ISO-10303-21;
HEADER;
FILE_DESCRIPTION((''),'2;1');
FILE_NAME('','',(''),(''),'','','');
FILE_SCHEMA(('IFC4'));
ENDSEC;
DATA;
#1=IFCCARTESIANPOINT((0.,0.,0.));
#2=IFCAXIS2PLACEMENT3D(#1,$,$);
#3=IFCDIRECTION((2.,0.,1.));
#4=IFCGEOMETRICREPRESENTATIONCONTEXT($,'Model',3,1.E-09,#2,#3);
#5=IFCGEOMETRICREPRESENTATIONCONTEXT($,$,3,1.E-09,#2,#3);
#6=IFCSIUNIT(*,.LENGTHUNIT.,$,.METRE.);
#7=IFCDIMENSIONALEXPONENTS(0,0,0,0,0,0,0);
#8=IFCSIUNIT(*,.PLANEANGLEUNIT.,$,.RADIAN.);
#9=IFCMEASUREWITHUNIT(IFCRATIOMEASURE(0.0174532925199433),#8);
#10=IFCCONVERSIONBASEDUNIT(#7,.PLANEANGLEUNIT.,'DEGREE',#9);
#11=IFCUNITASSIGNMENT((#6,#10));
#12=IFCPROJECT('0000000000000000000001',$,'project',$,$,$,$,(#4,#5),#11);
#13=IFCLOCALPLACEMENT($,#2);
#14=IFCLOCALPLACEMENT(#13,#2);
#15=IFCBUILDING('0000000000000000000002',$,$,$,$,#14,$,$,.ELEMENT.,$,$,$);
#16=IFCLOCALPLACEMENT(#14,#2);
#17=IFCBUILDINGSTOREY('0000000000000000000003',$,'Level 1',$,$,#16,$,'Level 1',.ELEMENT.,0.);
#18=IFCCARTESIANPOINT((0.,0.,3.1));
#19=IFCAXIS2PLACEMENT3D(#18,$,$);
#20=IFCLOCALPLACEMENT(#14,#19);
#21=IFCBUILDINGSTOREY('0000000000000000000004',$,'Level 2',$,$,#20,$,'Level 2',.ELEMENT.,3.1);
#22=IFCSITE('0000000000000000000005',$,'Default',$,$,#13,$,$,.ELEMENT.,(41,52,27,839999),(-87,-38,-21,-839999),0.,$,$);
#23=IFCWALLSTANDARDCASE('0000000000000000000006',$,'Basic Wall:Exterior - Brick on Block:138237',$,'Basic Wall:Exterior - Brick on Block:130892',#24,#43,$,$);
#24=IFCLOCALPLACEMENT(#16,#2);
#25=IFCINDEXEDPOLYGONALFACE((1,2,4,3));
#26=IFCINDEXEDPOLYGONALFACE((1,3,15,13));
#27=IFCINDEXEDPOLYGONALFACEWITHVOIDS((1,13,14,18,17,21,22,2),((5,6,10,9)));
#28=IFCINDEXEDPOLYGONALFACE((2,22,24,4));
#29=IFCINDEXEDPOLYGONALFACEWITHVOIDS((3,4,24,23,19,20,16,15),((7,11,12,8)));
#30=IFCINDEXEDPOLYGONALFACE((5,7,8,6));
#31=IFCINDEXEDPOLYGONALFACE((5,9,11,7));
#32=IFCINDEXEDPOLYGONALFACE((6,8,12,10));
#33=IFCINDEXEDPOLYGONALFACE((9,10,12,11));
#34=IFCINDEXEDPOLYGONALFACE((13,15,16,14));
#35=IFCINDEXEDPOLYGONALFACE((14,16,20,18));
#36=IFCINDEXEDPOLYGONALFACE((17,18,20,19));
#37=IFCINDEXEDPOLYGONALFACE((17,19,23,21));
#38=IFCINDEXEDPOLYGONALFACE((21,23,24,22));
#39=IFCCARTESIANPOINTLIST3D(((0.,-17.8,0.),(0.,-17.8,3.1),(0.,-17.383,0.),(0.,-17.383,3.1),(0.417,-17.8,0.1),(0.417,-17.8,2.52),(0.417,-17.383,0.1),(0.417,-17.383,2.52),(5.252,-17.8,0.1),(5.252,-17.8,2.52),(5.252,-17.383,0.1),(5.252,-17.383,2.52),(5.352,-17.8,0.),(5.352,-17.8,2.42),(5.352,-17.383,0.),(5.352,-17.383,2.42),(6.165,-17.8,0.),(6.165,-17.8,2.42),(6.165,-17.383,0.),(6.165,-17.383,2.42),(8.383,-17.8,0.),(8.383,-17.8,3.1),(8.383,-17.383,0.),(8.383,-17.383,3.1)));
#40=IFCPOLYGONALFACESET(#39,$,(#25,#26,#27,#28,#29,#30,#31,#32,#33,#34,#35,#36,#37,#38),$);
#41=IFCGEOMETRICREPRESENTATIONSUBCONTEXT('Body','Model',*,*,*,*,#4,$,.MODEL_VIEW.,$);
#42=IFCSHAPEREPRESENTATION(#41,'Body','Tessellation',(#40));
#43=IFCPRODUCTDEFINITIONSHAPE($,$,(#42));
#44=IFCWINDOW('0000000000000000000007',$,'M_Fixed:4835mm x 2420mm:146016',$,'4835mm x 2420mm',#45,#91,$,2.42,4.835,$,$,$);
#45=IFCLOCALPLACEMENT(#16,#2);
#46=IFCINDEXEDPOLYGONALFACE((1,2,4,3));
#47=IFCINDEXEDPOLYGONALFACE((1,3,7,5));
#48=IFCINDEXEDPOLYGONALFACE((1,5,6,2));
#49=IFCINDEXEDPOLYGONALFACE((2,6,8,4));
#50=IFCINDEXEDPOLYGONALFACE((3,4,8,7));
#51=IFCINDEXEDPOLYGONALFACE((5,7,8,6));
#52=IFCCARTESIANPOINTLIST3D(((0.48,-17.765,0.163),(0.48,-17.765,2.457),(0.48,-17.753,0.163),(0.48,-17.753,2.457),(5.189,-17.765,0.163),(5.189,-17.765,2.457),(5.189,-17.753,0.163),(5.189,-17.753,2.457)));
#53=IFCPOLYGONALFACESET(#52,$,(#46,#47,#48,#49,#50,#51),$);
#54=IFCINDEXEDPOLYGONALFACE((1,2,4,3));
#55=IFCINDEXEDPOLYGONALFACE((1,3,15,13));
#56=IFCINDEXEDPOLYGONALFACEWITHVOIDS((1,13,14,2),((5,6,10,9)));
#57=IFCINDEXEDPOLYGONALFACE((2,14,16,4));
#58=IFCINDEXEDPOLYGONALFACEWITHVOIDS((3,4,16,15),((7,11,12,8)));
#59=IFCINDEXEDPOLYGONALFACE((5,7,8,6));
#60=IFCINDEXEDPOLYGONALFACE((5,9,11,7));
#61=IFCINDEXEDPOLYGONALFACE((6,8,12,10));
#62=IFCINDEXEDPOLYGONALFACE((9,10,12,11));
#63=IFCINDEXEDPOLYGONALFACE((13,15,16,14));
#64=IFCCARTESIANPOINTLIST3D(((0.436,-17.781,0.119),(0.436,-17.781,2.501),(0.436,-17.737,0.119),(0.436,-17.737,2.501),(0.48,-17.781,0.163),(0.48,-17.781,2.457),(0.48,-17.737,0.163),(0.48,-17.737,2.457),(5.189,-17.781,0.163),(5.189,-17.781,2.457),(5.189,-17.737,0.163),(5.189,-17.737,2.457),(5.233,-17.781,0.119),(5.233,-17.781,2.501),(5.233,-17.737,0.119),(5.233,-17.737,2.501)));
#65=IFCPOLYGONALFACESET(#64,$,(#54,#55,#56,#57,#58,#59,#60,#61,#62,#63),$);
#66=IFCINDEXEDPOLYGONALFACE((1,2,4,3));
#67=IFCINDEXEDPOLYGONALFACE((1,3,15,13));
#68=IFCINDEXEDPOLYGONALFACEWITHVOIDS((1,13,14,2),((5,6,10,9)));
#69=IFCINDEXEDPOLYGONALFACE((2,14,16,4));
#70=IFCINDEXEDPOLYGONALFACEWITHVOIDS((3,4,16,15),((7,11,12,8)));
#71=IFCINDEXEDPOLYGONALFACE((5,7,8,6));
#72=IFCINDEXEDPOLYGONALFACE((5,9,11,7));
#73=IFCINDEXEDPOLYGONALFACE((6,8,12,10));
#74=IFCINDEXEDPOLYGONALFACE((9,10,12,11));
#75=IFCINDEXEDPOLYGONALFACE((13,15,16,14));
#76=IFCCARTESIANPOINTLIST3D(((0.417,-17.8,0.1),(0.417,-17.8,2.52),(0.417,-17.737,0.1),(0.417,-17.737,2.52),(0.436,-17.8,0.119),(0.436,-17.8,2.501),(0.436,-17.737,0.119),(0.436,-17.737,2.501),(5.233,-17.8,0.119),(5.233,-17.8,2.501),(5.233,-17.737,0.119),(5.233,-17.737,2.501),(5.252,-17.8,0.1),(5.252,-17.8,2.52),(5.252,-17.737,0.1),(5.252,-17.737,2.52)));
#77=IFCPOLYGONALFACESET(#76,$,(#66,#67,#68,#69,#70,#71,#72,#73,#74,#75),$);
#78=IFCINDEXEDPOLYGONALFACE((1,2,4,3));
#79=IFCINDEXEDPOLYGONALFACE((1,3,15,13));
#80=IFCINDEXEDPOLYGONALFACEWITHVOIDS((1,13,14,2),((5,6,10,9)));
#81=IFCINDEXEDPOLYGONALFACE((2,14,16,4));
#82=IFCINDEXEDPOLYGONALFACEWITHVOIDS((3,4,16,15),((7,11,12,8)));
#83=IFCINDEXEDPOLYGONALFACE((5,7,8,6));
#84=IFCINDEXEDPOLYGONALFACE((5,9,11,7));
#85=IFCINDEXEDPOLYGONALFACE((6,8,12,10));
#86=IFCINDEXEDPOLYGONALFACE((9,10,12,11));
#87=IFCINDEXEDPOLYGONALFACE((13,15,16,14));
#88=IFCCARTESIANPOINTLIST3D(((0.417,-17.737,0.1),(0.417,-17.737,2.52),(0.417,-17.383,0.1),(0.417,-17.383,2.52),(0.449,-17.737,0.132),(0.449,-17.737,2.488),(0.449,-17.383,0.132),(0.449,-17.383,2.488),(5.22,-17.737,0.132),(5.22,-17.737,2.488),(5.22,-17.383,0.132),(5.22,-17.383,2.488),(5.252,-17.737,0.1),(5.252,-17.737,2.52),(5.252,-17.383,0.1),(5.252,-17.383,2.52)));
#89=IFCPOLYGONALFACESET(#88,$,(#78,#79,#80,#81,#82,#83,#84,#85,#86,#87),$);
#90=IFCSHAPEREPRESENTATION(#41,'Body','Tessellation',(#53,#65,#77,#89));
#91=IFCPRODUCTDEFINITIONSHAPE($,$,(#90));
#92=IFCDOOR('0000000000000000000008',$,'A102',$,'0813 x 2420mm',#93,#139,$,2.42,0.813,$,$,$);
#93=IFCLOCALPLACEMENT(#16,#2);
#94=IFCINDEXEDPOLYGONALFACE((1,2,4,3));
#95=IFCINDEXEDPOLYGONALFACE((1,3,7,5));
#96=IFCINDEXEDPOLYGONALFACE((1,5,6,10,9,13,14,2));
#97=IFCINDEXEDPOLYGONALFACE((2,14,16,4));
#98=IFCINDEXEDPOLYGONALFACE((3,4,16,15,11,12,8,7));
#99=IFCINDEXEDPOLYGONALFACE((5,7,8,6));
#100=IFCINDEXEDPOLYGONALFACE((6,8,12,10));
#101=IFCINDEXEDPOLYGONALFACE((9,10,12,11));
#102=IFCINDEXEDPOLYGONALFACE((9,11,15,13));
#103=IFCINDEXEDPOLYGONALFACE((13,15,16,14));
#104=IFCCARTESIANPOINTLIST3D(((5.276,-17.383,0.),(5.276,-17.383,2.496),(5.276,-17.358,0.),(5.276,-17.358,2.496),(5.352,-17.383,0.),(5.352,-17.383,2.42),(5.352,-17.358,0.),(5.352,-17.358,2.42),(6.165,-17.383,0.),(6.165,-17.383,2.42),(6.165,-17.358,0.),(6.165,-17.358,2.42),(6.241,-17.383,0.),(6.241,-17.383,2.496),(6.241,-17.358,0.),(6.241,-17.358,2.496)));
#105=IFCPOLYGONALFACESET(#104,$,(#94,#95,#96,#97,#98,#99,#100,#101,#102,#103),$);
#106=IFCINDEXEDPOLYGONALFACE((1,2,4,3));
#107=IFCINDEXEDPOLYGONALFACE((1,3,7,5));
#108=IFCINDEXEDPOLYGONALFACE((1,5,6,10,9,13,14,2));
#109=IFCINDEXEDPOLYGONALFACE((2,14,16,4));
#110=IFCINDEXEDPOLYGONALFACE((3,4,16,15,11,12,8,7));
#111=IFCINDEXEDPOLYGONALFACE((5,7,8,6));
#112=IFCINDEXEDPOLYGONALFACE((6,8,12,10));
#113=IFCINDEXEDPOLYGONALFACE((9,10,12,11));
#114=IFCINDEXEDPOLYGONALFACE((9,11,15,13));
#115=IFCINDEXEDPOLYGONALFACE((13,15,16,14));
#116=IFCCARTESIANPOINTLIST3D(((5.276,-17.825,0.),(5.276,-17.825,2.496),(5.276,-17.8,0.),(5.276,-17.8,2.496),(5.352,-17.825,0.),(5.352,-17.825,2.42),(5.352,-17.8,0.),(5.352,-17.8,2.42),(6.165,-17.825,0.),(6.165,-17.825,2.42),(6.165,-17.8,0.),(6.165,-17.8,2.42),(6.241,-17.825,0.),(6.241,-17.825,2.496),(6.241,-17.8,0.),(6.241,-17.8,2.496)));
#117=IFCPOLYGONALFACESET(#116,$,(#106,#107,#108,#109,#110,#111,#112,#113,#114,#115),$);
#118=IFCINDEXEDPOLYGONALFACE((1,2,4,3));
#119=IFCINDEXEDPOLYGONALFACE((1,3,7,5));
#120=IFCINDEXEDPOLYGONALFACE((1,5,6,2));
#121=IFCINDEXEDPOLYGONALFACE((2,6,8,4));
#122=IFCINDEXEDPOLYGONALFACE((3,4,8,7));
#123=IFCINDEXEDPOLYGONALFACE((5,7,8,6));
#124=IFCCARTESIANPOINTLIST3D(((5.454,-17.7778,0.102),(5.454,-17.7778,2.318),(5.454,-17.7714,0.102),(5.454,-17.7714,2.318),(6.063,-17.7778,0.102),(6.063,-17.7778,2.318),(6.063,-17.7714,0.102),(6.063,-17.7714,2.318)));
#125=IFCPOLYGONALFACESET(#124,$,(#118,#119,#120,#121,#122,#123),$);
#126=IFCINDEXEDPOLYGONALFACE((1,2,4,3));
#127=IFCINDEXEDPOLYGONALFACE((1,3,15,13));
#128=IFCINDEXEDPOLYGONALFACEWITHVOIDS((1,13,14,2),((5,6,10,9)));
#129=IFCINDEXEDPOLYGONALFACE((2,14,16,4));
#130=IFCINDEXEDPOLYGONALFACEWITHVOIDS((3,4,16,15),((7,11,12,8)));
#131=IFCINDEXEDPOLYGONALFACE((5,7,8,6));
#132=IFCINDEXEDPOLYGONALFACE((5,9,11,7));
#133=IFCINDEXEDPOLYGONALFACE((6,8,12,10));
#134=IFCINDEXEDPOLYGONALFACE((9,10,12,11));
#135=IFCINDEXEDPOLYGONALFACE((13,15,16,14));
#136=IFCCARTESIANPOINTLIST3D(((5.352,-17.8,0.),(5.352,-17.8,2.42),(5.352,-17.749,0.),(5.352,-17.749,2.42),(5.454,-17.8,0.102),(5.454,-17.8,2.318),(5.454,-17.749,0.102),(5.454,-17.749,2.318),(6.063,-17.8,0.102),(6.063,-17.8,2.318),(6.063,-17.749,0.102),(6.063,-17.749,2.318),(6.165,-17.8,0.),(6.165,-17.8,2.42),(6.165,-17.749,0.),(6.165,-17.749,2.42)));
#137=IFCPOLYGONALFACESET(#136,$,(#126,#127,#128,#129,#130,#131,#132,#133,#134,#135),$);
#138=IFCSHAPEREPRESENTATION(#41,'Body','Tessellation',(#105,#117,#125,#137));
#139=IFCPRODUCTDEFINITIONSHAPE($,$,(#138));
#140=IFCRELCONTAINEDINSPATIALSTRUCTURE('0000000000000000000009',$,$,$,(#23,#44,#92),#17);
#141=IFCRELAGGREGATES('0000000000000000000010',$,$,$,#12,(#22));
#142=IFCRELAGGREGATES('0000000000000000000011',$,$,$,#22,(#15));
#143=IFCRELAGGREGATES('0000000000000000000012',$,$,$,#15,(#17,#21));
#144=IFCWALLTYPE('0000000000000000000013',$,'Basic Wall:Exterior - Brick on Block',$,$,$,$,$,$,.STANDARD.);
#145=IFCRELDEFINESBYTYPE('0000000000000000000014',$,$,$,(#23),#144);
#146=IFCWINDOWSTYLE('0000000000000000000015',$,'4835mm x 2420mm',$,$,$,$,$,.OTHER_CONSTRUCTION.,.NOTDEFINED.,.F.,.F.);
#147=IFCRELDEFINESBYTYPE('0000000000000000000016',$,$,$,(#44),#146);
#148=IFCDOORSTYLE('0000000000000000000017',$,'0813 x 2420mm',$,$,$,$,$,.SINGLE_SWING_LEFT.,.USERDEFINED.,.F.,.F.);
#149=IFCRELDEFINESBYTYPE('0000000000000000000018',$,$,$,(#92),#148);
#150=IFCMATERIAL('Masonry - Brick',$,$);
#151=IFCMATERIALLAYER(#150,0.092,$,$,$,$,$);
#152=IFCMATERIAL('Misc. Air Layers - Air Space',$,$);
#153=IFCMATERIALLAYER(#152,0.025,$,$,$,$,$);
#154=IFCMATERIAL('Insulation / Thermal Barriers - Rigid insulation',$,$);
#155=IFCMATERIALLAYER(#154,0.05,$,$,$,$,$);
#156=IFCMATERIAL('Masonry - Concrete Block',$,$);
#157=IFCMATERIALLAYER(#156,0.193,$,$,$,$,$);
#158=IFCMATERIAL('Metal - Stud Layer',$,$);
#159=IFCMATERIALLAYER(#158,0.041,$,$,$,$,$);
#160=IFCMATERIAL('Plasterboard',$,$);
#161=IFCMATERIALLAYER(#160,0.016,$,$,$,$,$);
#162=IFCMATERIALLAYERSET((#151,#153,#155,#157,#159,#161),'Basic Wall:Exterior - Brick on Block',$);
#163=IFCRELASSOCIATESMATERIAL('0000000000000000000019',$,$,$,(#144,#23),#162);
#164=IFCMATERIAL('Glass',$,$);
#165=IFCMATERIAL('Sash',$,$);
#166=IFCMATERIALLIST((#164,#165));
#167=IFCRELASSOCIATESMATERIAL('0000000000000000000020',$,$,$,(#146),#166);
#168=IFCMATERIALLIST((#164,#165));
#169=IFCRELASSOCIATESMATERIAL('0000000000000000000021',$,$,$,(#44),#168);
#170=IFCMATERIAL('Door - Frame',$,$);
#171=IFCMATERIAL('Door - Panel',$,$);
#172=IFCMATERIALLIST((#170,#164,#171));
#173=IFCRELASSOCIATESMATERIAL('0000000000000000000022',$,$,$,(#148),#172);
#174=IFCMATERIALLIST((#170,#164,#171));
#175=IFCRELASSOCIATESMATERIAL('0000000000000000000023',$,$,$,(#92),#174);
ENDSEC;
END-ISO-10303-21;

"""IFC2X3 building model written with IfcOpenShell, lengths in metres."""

from ifc_helpers import new_model, entity, si_unit, converted_unit, direction, frame, frame_2d, origin, origin_2d_with_axis, place, context, subcontext, project, spatial, polyline, rectangle, outline, extrude, source, transform, mapped, material, material_list, layer, layer_set, layer_usage, type_object, type_shapes, element, fill, save


model = new_model("IFC2X3")

# Units and contexts
model_context = context("Model", 3, precision=1e-09, world=origin(), true_north=direction((2.0, 0.0, 1.0)))
context_of_model = context(None, 3, precision=1e-09, world=origin(), true_north=direction((2.0, 0.0, 1.0)))
body_context = subcontext(model_context, "Body", "Model", "MODEL_VIEW")
ifc_project = project(units=[si_unit("LENGTHUNIT", "METRE"), converted_unit("PLANEANGLEUNIT", "DEGREE", entity("IfcRatioMeasure", 0.0174532925199433), si_unit("PLANEANGLEUNIT", "RADIAN"), dimensions=[0, 0, 0, 0, 0, 0, 0])], contexts=[model_context, context_of_model])

# Site, building, storey
site_placement = place(None, origin())
site = spatial("IfcSite", under=ifc_project, at=site_placement, Name="Default", CompositionType="ELEMENT", RefLatitude=(41, 52, 27, 839999), RefLongitude=(-87, -38, -21, -839999), RefElevation=0.0)
building_placement = place(site_placement, origin())
building = spatial("IfcBuilding", under=site, at=building_placement, CompositionType="ELEMENT")
storey_1_placement = place(building_placement, origin())
storey_1 = spatial("IfcBuildingStorey", under=building, at=storey_1_placement, Name="Level 1", LongName="Level 1", CompositionType="ELEMENT", Elevation=0.0)

# Wall, openings, window, door
ifc_material_1 = material(Name="Masonry - Brick")
ifc_layer_1 = layer(ifc_material_1, 0.092)
ifc_material_2 = material(Name="Misc. Air Layers - Air Space")
ifc_layer_2 = layer(ifc_material_2, 0.025)
ifc_material_3 = material(Name="Insulation / Thermal Barriers - Rigid insulation")
ifc_layer_3 = layer(ifc_material_3, 0.05)
ifc_material_4 = material(Name="Masonry - Concrete Block")
ifc_layer_4 = layer(ifc_material_4, 0.193)
ifc_material_5 = material(Name="Metal - Stud Layer")
ifc_layer_5 = layer(ifc_material_5, 0.041)
ifc_material_6 = material(Name="Plasterboard")
ifc_layer_6 = layer(ifc_material_6, 0.016)
ifc_layer_set_1 = layer_set([ifc_layer_1, ifc_layer_2, ifc_layer_3, ifc_layer_4, ifc_layer_5, ifc_layer_6], Name="Basic Wall:Exterior - Brick on Block")
ifc_layer_usage_1 = layer_usage(ifc_layer_set_1, "AXIS2", "NEGATIVE", 0.2085)
wall_type_1 = type_object("IfcWallType", Name="Basic Wall:Exterior - Brick on Block", PredefinedType="STANDARD", material=ifc_layer_set_1)
wall_1_placement = place(storey_1_placement, frame((8.383, -17.5915, 0.0), z_axis=(0.0, 0.0, 1.0), x_axis=(-1.0, 0.0, 0.0)))
wall_1 = element("IfcWallStandardCase", 1, at=wall_1_placement, inside=storey_1, type_object=wall_type_1, material=ifc_layer_usage_1, Name="Basic Wall:Exterior - Brick on Block:138237", ObjectType="Basic Wall:Exterior - Brick on Block:130892", context=body_context, shape_type="SweptSolid", body=[
    extrude(rectangle(XDim=8.383, YDim=0.417, at=frame_2d((4.1915, 0.0), x_axis=(-1.0, 0.0))), origin(), (0.0, 0.0, 1.0), 3.1),
])
opening_1_placement = place(wall_1_placement, frame((3.131, -0.2085, 0.1)))
opening_1 = element("IfcOpeningElement", 2, at=opening_1_placement, cuts=wall_1, ObjectType="Opening", context=body_context, shape_type="SweptSolid", body=[
    extrude(rectangle(XDim=2.42, YDim=4.835, at=frame_2d((1.21, 2.4175), x_axis=(1.0, 0.0))), frame((0.0, 0.0, 0.0), z_axis=(0.0, 1.0, 0.0), x_axis=(0.0, 0.0, 1.0)), (0.0, 0.0, 1.0), 0.417),
])
opening_2_placement = place(wall_1_placement, frame((2.218, -0.2085, 0.0)))
opening_2 = element("IfcOpeningElement", 3, at=opening_2_placement, cuts=wall_1, ObjectType="Opening", context=body_context, shape_type="SweptSolid", body=[
    extrude(rectangle(XDim=0.813, YDim=2.42, at=frame_2d((1.21, 0.4065), x_axis=(0.0, -1.0))), frame((0.0, 0.0, 0.0), z_axis=(0.0, 1.0, 0.0), x_axis=(0.0, 0.0, 1.0)), (0.0, 0.0, 1.0), 0.417),
])
ifc_material_7 = material(Name="Glass")
ifc_material_8 = material(Name="Sash")
ifc_material_list_1 = material_list([ifc_material_7, ifc_material_8])
ifc_material_list_2 = material_list([ifc_material_7, ifc_material_8])
window_style_1 = type_object("IfcWindowStyle", Name="4835mm x 2420mm", ConstructionType="OTHER_CONSTRUCTION", OperationType="NOTDEFINED", ParameterTakesPrecedence=False, Sizeable=False, material=ifc_material_list_2)
shared_shape_1 = source(origin(), body_context, "Body", "SweptSolid", [
    extrude(rectangle(XDim=0.012, YDim=4.709, at=origin_2d_with_axis()), frame((2.4175, 0.376, 0.063), z_axis=(0.0, 0.0, 1.0), x_axis=(0.0, -1.0, 0.0)), (0.0, 0.0, 1.0), 2.294),
    extrude(outline(polyline([(-2.3985, -1.191), (2.3985, -1.191), (2.3985, 1.191), (-2.3985, 1.191), (-2.3985, -1.191)]), holes=[polyline([(-2.3545, -1.147), (-2.3545, 1.147), (2.3545, 1.147), (2.3545, -1.147), (-2.3545, -1.147)])]), frame((2.4175, 0.354, 1.21), z_axis=(0.0, 1.0, 0.0), x_axis=(1.0, 0.0, 0.0)), (0.0, 0.0, 1.0), 0.044),
    extrude(outline(polyline([(-2.4175, -1.21), (2.4175, -1.21), (2.4175, 1.21), (-2.4175, 1.21), (-2.4175, -1.21)]), holes=[polyline([(-2.3985, -1.191), (-2.3985, 1.191), (2.3985, 1.191), (2.3985, -1.191), (-2.3985, -1.191)])]), frame((2.4175, 0.354, 1.21), z_axis=(0.0, 1.0, 0.0), x_axis=(1.0, 0.0, 0.0)), (0.0, 0.0, 1.0), 0.063),
    extrude(outline(polyline([(-2.4175, -1.21), (2.4175, -1.21), (2.4175, 1.21), (-2.4175, 1.21), (-2.4175, -1.21)]), holes=[polyline([(-2.3855, -1.178), (-2.3855, 1.178), (2.3855, 1.178), (2.3855, -1.178), (-2.3855, -1.178)])]), frame((2.4175, 0.0, 1.21), z_axis=(0.0, 1.0, 0.0), x_axis=(1.0, 0.0, 0.0)), (0.0, 0.0, 1.0), 0.354),
])
type_shapes(window_style_1, [shared_shape_1])
window_1_placement = place(opening_1_placement, origin())
window_1 = element("IfcWindow", 4, at=window_1_placement, inside=storey_1, type_object=window_style_1, material=ifc_material_list_1, Name="M_Fixed:4835mm x 2420mm:146016", ObjectType="4835mm x 2420mm", OverallHeight=2.42, OverallWidth=4.835, context=body_context, shape_type="MappedRepresentation", body=[
    mapped(shared_shape_1, transform((0.0, 0.0, 0.0), scale=1.0)),
])
fill(opening_1, window_1)
ifc_material_9 = material(Name="Door - Frame")
ifc_material_10 = material(Name="Door - Panel")
ifc_material_list_3 = material_list([ifc_material_9, ifc_material_7, ifc_material_10])
ifc_material_list_4 = material_list([ifc_material_9, ifc_material_7, ifc_material_10])
door_style_1 = type_object("IfcDoorStyle", Name="0813 x 2420mm", ConstructionType="USERDEFINED", OperationType="SINGLE_SWING_LEFT", ParameterTakesPrecedence=False, Sizeable=False, material=ifc_material_list_4)
shared_shape_2 = source(origin(), body_context, "Body", "SweptSolid", [
    extrude(outline(polyline([(-0.4065, -1.191), (-0.4065, 1.229), (-0.4825, 1.229), (-0.4825, -1.267), (0.4825, -1.267), (0.4825, 1.229), (0.4065, 1.229), (0.4065, -1.191), (-0.4065, -1.191)])), frame((0.4065, 0.0, 1.229), z_axis=(0.0, 1.0, 0.0), x_axis=(1.0, 0.0, 0.0)), (0.0, 0.0, -1.0), 0.025),
    extrude(outline(polyline([(-0.4065, -1.191), (-0.4065, 1.229), (-0.4825, 1.229), (-0.4825, -1.267), (0.4825, -1.267), (0.4825, 1.229), (0.4065, 1.229), (0.4065, -1.191), (-0.4065, -1.191)])), frame((0.4065, 0.442, 1.229), z_axis=(0.0, 1.0, 0.0), x_axis=(1.0, 0.0, 0.0)), (0.0, 0.0, -1.0), 0.025),
    extrude(rectangle(XDim=0.609, YDim=0.0064, at=frame_2d((0.0, 0.0), x_axis=(1.0, 0.0))), frame((0.4065, 0.3916, 0.102)), (0.0, 0.0, 1.0), 2.216),
    extrude(outline(polyline([(-1.21, -0.4065), (1.21, -0.4065), (1.21, 0.4065), (-1.21, 0.4065), (-1.21, -0.4065)]), holes=[polyline([(-1.108, 0.3045), (1.108, 0.3045), (1.108, -0.3045), (-1.108, -0.3045), (-1.108, 0.3045)])]), frame((0.4065, 0.417, 1.21), z_axis=(0.0, -1.0, 0.0), x_axis=(0.0, 0.0, -1.0)), (0.0, 0.0, 1.0), 0.051),
])
type_shapes(door_style_1, [shared_shape_2])
door_1_placement = place(opening_2_placement, origin())
door_1 = element("IfcDoor", 5, at=door_1_placement, inside=storey_1, type_object=door_style_1, material=ifc_material_list_3, Name="A102", ObjectType="0813 x 2420mm", OverallHeight=2.42, OverallWidth=0.813, context=body_context, shape_type="MappedRepresentation", body=[
    mapped(shared_shape_2, transform((0.0, 0.0, 0.0), scale=1.0)),
])
fill(opening_2, door_1)

# Shared definitions
storey_2_placement = place(building_placement, frame((0.0, 0.0, 3.1)))
storey_2 = spatial("IfcBuildingStorey", under=building, at=storey_2_placement, Name="Level 2", LongName="Level 2", CompositionType="ELEMENT", Elevation=3.1)

save(model, "model.ifc")
